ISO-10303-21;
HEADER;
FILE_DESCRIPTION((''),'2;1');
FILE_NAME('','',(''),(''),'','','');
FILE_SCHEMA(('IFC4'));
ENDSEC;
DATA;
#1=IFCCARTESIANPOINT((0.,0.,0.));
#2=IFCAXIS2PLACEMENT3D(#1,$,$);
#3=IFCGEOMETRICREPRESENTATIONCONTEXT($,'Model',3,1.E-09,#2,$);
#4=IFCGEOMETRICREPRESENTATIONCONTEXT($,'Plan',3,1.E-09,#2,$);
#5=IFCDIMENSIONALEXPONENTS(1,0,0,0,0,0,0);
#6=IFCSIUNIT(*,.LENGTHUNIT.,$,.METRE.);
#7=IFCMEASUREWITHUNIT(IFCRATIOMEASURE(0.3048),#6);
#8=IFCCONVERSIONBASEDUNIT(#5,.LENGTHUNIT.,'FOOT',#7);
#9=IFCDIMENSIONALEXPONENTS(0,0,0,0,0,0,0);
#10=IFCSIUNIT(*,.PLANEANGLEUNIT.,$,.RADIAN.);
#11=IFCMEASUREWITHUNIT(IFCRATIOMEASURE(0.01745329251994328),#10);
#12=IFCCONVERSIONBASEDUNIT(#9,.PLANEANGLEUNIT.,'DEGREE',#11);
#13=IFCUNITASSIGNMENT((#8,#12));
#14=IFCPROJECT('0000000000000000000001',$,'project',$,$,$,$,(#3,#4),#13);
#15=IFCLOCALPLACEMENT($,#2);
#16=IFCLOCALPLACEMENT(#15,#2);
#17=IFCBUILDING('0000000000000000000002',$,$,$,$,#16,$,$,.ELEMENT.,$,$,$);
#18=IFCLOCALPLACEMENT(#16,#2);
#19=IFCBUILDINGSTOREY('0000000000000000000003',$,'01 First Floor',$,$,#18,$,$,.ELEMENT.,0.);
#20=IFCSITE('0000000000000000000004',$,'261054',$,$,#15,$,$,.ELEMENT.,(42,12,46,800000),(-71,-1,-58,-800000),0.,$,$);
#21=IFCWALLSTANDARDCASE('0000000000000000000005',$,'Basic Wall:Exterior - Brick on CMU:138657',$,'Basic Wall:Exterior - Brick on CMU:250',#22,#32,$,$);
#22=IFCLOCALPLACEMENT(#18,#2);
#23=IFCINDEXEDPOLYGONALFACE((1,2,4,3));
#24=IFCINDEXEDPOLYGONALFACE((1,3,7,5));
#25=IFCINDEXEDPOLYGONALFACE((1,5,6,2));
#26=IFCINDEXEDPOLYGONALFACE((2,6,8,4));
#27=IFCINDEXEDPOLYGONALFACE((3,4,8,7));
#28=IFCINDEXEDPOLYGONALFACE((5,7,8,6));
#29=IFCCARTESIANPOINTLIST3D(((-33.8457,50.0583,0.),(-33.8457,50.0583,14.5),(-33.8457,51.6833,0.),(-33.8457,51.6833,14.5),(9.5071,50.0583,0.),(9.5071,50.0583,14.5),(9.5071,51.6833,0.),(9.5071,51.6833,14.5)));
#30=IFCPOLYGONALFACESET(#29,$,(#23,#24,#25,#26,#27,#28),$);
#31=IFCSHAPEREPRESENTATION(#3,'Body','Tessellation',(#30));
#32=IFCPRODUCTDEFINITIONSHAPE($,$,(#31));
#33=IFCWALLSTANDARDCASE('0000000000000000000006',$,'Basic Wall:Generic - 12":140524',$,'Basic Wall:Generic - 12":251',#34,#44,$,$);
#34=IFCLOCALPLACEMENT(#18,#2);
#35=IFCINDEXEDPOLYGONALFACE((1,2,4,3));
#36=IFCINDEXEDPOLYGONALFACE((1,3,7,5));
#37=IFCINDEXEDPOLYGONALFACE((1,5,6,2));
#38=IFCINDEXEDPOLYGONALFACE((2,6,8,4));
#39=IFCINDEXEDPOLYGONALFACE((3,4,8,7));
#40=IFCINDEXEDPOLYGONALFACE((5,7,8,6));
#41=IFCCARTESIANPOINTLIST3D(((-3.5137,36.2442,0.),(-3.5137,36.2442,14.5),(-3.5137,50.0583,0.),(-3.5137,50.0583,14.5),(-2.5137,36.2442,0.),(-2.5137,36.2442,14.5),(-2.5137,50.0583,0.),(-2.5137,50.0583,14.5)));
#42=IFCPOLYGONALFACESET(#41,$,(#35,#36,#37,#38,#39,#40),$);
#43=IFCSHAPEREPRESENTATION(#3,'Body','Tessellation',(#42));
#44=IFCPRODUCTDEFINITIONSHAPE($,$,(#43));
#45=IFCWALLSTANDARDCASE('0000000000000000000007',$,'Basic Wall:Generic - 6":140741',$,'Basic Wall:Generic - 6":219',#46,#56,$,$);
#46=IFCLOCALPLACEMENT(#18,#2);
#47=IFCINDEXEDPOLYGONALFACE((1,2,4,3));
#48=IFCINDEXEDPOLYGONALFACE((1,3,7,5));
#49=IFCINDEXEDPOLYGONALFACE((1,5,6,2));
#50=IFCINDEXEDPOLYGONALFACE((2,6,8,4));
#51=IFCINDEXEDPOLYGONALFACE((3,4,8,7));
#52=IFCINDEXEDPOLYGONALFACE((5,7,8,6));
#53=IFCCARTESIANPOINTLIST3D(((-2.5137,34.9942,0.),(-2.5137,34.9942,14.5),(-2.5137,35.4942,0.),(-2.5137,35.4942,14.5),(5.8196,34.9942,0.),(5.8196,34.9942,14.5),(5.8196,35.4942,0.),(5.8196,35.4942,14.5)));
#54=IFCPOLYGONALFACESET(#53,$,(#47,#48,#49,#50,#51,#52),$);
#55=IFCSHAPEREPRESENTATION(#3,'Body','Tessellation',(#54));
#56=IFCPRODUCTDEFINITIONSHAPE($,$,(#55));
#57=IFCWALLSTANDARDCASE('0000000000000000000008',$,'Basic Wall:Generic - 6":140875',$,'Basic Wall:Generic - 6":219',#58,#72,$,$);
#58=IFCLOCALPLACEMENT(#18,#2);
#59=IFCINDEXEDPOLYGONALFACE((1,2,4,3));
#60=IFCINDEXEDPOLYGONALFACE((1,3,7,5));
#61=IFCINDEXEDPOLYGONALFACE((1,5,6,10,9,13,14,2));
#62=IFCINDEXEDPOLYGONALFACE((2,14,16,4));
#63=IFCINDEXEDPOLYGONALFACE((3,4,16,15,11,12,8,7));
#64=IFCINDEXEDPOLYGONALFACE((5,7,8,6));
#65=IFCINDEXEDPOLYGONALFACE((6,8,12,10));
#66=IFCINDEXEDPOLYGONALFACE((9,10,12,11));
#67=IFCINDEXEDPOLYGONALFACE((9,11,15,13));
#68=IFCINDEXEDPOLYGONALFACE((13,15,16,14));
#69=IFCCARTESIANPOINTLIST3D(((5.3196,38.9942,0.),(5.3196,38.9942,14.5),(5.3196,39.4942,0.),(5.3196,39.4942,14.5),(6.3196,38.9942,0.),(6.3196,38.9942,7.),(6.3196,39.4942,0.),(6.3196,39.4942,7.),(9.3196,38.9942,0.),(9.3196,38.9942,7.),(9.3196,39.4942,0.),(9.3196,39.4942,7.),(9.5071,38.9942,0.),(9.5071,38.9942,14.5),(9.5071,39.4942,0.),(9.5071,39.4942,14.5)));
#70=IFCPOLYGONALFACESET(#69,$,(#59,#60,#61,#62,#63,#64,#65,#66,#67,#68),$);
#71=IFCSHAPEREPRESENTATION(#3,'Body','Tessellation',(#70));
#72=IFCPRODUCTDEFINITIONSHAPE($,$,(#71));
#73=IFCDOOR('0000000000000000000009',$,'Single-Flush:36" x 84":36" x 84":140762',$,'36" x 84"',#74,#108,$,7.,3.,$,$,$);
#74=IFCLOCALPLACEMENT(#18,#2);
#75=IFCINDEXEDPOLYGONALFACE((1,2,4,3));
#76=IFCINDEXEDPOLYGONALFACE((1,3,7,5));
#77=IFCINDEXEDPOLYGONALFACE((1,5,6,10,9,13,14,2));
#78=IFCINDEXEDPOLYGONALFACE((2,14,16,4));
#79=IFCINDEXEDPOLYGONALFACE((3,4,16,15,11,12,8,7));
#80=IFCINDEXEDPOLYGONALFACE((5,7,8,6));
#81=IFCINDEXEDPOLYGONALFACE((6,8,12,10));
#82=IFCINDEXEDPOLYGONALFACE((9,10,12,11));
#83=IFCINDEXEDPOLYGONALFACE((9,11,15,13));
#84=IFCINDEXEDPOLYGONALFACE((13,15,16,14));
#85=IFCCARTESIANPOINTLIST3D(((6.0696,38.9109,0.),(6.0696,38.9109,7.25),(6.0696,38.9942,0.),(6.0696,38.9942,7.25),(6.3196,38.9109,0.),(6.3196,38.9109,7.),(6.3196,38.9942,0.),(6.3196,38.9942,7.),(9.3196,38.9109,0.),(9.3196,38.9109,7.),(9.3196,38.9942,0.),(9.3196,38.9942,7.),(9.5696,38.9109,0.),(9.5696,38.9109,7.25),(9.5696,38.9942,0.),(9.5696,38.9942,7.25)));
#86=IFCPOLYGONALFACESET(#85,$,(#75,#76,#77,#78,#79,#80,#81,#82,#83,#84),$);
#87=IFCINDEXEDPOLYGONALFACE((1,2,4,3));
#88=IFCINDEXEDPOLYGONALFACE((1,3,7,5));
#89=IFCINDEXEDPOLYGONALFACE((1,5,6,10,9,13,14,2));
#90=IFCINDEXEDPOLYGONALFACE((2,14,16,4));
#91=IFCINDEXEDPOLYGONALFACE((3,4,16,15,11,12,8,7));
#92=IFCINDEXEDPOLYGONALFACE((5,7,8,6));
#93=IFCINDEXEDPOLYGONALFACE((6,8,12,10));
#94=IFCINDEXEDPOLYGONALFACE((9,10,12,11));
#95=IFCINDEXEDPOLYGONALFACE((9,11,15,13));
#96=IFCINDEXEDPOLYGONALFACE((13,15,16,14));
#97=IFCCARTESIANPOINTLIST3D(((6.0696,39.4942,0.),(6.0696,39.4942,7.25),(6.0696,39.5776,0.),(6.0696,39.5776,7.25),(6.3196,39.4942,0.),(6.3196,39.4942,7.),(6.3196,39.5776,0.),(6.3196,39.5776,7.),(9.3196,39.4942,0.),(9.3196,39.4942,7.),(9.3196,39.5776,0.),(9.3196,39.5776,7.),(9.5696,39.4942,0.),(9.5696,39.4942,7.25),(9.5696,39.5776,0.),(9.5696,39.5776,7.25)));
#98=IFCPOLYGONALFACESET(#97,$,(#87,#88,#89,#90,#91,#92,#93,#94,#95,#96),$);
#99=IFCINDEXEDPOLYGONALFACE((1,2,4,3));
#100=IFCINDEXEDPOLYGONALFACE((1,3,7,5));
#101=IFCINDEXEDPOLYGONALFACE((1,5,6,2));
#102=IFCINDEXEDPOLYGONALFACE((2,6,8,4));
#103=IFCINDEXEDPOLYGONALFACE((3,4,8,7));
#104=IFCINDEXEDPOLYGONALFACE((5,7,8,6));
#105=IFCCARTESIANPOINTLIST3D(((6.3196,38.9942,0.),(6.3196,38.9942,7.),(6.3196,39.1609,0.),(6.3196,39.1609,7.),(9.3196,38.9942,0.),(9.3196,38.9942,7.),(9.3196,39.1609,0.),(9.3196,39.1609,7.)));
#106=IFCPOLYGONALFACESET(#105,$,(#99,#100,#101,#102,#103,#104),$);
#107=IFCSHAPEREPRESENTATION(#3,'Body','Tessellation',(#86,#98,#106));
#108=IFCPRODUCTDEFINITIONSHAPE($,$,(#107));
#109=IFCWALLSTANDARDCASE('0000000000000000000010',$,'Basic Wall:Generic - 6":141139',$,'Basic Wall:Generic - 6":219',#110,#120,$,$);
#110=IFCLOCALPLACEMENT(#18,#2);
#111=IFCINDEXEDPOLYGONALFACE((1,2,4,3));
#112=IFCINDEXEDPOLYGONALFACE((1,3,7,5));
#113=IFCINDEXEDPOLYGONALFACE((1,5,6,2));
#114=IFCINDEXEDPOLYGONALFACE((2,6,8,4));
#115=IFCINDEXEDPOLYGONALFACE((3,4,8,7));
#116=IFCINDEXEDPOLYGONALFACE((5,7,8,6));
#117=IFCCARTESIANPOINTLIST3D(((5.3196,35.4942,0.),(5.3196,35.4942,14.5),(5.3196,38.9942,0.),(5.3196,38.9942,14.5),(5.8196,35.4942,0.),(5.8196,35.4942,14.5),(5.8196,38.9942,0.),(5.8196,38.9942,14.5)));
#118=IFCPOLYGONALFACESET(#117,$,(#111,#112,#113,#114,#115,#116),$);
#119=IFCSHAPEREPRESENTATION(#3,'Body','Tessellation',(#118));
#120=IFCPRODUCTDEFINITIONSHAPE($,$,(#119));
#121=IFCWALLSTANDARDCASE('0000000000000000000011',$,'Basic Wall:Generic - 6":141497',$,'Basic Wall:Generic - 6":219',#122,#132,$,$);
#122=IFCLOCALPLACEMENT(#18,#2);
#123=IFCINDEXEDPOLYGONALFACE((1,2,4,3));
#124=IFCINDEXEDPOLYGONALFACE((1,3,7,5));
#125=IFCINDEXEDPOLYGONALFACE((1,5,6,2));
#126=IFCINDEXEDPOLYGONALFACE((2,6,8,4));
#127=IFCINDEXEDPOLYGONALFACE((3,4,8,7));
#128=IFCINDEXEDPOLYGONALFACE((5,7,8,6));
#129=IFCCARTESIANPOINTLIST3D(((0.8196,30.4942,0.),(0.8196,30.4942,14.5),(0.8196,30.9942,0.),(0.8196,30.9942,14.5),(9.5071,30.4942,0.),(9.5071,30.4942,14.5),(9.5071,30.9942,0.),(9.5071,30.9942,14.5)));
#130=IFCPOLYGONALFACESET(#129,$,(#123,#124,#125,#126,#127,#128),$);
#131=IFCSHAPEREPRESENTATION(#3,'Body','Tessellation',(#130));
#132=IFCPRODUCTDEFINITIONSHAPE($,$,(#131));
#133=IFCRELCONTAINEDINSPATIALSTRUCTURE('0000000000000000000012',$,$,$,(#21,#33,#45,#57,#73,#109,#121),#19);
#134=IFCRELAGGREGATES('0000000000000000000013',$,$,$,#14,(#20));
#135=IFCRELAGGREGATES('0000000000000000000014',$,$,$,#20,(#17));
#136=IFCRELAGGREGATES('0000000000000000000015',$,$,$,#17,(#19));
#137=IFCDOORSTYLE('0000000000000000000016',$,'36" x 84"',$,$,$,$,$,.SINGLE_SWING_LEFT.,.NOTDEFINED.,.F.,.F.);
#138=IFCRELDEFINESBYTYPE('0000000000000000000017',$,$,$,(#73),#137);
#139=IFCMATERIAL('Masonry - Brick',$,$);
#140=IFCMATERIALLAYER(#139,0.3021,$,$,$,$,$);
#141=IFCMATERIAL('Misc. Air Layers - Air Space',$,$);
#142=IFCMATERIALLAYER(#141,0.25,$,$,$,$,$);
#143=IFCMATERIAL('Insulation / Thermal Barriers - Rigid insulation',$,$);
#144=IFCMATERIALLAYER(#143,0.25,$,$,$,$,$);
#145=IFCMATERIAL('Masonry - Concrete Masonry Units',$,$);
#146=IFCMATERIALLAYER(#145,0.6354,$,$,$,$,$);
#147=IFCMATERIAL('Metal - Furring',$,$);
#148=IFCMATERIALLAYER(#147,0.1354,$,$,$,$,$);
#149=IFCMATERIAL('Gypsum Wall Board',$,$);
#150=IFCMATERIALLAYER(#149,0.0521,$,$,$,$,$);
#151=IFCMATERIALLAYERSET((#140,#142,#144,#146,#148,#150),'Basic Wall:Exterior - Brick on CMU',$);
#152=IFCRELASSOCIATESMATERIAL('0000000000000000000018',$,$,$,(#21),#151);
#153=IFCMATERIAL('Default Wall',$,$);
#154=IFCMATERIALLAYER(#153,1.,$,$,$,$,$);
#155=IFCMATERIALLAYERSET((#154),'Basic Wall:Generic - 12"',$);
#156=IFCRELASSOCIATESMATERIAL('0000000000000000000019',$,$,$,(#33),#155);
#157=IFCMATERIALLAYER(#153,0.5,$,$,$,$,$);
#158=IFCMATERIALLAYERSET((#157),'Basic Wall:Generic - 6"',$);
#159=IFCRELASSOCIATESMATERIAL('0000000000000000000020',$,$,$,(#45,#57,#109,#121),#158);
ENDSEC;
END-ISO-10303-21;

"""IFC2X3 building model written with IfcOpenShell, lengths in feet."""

from ifc_helpers import new_model, entity, si_unit, converted_unit, frame, frame_2d, origin, origin_2d_with_axis, place, context, project, spatial, polyline, rectangle, outline, extrude, clip, bounded_halfspace, source, transform, mapped, material, layer, layer_set, layer_usage, type_object, type_shapes, element, fill, save


model = new_model("IFC2X3")

# Units and contexts
model_context = context("Model", 3, precision=1e-09, world=origin())
plan_context = context("Plan", 3, precision=1e-09, world=origin())
ifc_project = project(units=[converted_unit("LENGTHUNIT", "FOOT", entity("IfcRatioMeasure", 0.3048), si_unit("LENGTHUNIT", "METRE"), dimensions=[1, 0, 0, 0, 0, 0, 0]), converted_unit("PLANEANGLEUNIT", "DEGREE", entity("IfcRatioMeasure", 0.01745329251994328), si_unit("PLANEANGLEUNIT", "RADIAN"), dimensions=[0, 0, 0, 0, 0, 0, 0])], contexts=[model_context, plan_context])

# Site, building, storey
site_placement = place(None, origin())
site = spatial("IfcSite", under=ifc_project, at=site_placement, Name="261054", CompositionType="ELEMENT", RefLatitude=(42, 12, 46, 800000), RefLongitude=(-71, -1, -58, -800000), RefElevation=0.0)
building_placement = place(site_placement, origin())
building = spatial("IfcBuilding", under=site, at=building_placement, CompositionType="ELEMENT")
storey_placement = place(building_placement, origin())
storey = spatial("IfcBuildingStorey", under=building, at=storey_placement, Name="01 First Floor", CompositionType="ELEMENT", Elevation=0.0)

# Walls
ifc_material_1 = material(Name="Masonry - Brick")
ifc_layer_1 = layer(ifc_material_1, 0.3021)
ifc_material_2 = material(Name="Misc. Air Layers - Air Space")
ifc_layer_2 = layer(ifc_material_2, 0.25)
ifc_material_3 = material(Name="Insulation / Thermal Barriers - Rigid insulation")
ifc_layer_3 = layer(ifc_material_3, 0.25)
ifc_material_4 = material(Name="Masonry - Concrete Masonry Units")
ifc_layer_4 = layer(ifc_material_4, 0.6354)
ifc_material_5 = material(Name="Metal - Furring")
ifc_layer_5 = layer(ifc_material_5, 0.1354)
ifc_material_6 = material(Name="Gypsum Wall Board")
ifc_layer_6 = layer(ifc_material_6, 0.0521)
ifc_layer_set_1 = layer_set([ifc_layer_1, ifc_layer_2, ifc_layer_3, ifc_layer_4, ifc_layer_5, ifc_layer_6], Name="Basic Wall:Exterior - Brick on CMU")
ifc_layer_usage_1 = layer_usage(ifc_layer_set_1, "AXIS2", "POSITIVE", -0.8125)
wall_1_placement = place(storey_placement, frame((9.5071, 50.8708, 0.0), z_axis=(0.0, 0.0, 1.0), x_axis=(-1.0, 0.0, 0.0)))
element("IfcWallStandardCase", 1, at=wall_1_placement, inside=storey, material=ifc_layer_usage_1, Name="Basic Wall:Exterior - Brick on CMU:138657", ObjectType="Basic Wall:Exterior - Brick on CMU:250", context=model_context, shape_type="Clipping", body=[
    clip(extrude(rectangle(XDim=43.3528, YDim=1.625, at=frame_2d((21.6764, 0.0), x_axis=(-1.0, 0.0))), origin(), (0.0, 0.0, 1.0), 14.5), bounded_halfspace(frame((0.0, -0.8125, 14.5), z_axis=(0.0, 0.0, -1.0), x_axis=(-1.0, 0.0, 0.0)), True, frame((0.0, -0.8125, 14.5)), polyline([(0.0, 0.0), (8.1875, 0.0), (43.3528, 0.0), (43.3528, 1.625), (41.7278, 1.625), (13.0208, 1.625), (12.0208, 1.625), (0.0, 1.625), (0.0, 0.0)]))),
])
ifc_material_7 = material(Name="Default Wall")
ifc_layer_7 = layer(ifc_material_7, 1.0)
ifc_layer_set_2 = layer_set([ifc_layer_7], Name="Basic Wall:Generic - 12\"")
ifc_layer_usage_2 = layer_usage(ifc_layer_set_2, "AXIS2", "NEGATIVE", 0.5)
wall_2_placement = place(storey_placement, frame((-3.0137, 36.2442, 0.0), z_axis=(0.0, 0.0, 1.0), x_axis=(0.0, 1.0, 0.0)))
element("IfcWallStandardCase", 2, at=wall_2_placement, inside=storey, material=ifc_layer_usage_2, Name="Basic Wall:Generic - 12\":140524", ObjectType="Basic Wall:Generic - 12\":251", context=model_context, shape_type="Clipping", body=[
    clip(extrude(rectangle(XDim=13.814, YDim=1.0, at=frame_2d((6.907, 0.0), x_axis=(-1.0, 0.0))), origin(), (0.0, 0.0, 1.0), 14.5), bounded_halfspace(frame((0.0, -0.5, 14.5), z_axis=(0.0, 0.0, -1.0), x_axis=(0.0, -1.0, 0.0)), True, frame((0.0, -0.5, 14.5)), polyline([(0.0, 0.0), (13.814, 0.0), (13.814, 1.0), (0.0, 1.0), (0.0, 0.0)]))),
])
ifc_layer_8 = layer(ifc_material_7, 0.5)
ifc_layer_set_3 = layer_set([ifc_layer_8], Name="Basic Wall:Generic - 6\"")
ifc_layer_usage_3 = layer_usage(ifc_layer_set_3, "AXIS2", "NEGATIVE", 0.25)
wall_3_placement = place(storey_placement, frame((-2.5137, 35.2442, 0.0)))
element("IfcWallStandardCase", 3, at=wall_3_placement, inside=storey, material=ifc_layer_usage_3, Name="Basic Wall:Generic - 6\":140741", ObjectType="Basic Wall:Generic - 6\":219", context=model_context, shape_type="Clipping", body=[
    clip(extrude(rectangle(XDim=8.3333, YDim=0.5, at=frame_2d((4.1667, 0.0), x_axis=(-1.0, 0.0))), origin(), (0.0, 0.0, 1.0), 14.5), bounded_halfspace(frame((0.0, -0.25, 14.5), z_axis=(0.0, 0.0, -1.0), x_axis=(1.0, 0.0, 0.0)), True, frame((0.0, -0.25, 14.5)), polyline([(0.0, 0.0), (8.3333, 0.0), (8.3333, 0.5), (7.8333, 0.5), (0.0, 0.5), (0.0, 0.0)]))),
])

# Wall, opening, door
ifc_layer_usage_4 = layer_usage(ifc_layer_set_3, "AXIS2", "NEGATIVE", 0.25)
wall_4_placement = place(storey_placement, frame((5.3196, 39.2442, 0.0)))
wall_4 = element("IfcWallStandardCase", 4, at=wall_4_placement, inside=storey, material=ifc_layer_usage_4, Name="Basic Wall:Generic - 6\":140875", ObjectType="Basic Wall:Generic - 6\":219", context=model_context, shape_type="Clipping", body=[
    clip(extrude(rectangle(XDim=4.1875, YDim=0.5, at=frame_2d((2.0938, 0.0), x_axis=(-1.0, 0.0))), origin(), (0.0, 0.0, 1.0), 14.5), bounded_halfspace(frame((0.0, -0.25, 14.5), z_axis=(0.0, 0.0, -1.0), x_axis=(1.0, 0.0, 0.0)), True, frame((0.0, -0.25, 14.5)), polyline([(0.0, 0.0), (0.5, 0.0), (4.1875, 0.0), (4.1875, 0.5), (0.0, 0.5), (0.0, 0.0)]))),
])
opening_1_placement = place(wall_4_placement, frame((4.0, 0.25, 0.0)))
opening_1 = element("IfcOpeningElement", 5, at=opening_1_placement, cuts=wall_4, ObjectType="Opening", context=model_context, shape_type="SweptSolid", body=[
    extrude(rectangle(XDim=3.0, YDim=7.0, at=frame_2d((3.5, 1.5), x_axis=(0.0, -1.0))), frame((0.0, 0.0, 0.0), z_axis=(0.0, -1.0, 0.0), x_axis=(0.0, 0.0, 1.0)), (0.0, 0.0, 1.0), 0.5),
])
door_style_1 = type_object("IfcDoorStyle", Name="36\" x 84\"", ConstructionType="NOTDEFINED", OperationType="SINGLE_SWING_LEFT", ParameterTakesPrecedence=False, Sizeable=False)
shared_shape_1 = source(origin(), model_context, "Body", "SweptSolid", [
    extrude(outline(polyline([(-1.75, -3.6875), (1.75, -3.6875), (1.75, 3.5625), (1.5, 3.5625), (1.5, -3.4375), (-1.5, -3.4375), (-1.5, 3.5625), (-1.75, 3.5625), (-1.75, -3.6875)])), frame((1.5, 0.5833, 3.5625), z_axis=(0.0, -1.0, 0.0), x_axis=(-1.0, 0.0, 0.0)), (0.0, 0.0, 1.0), 0.0833),
    extrude(outline(polyline([(-3.6875, -1.75), (3.5625, -1.75), (3.5625, -1.5), (-3.4375, -1.5), (-3.4375, 1.5), (3.5625, 1.5), (3.5625, 1.75), (-3.6875, 1.75), (-3.6875, -1.75)])), frame((1.5, 0.0, 3.5625), z_axis=(0.0, -1.0, 0.0), x_axis=(0.0, 0.0, -1.0)), (0.0, 0.0, 1.0), 0.0833),
    extrude(rectangle(XDim=3.0, YDim=0.1667, at=origin_2d_with_axis()), frame((1.5, 0.4167, 0.0)), (0.0, 0.0, 1.0), 7.0),
])
type_shapes(door_style_1, [shared_shape_1])
door_1_placement = place(opening_1_placement, frame((0.0, 0.0, 0.0), z_axis=(0.0, 0.0, 1.0), x_axis=(-1.0, 0.0, 0.0)))
door_1 = element("IfcDoor", 6, at=door_1_placement, inside=storey, type_object=door_style_1, Name="Single-Flush:36\" x 84\":36\" x 84\":140762", ObjectType="36\" x 84\"", OverallHeight=7.0, OverallWidth=3.0, context=model_context, shape_type="MappedRepresentation", body=[
    mapped(shared_shape_1, transform((0.0, 0.0, 0.0), scale=1.0)),
])
fill(opening_1, door_1)

# Walls
ifc_layer_usage_5 = layer_usage(ifc_layer_set_3, "AXIS2", "NEGATIVE", 0.25)
wall_5_placement = place(storey_placement, frame((5.5696, 35.4942, 0.0), z_axis=(0.0, 0.0, 1.0), x_axis=(0.0, 1.0, 0.0)))
element("IfcWallStandardCase", 7, at=wall_5_placement, inside=storey, material=ifc_layer_usage_5, Name="Basic Wall:Generic - 6\":141139", ObjectType="Basic Wall:Generic - 6\":219", context=model_context, shape_type="Clipping", body=[
    clip(extrude(rectangle(XDim=3.5, YDim=0.5, at=frame_2d((1.75, 0.0), x_axis=(-1.0, 0.0))), origin(), (0.0, 0.0, 1.0), 14.5), bounded_halfspace(frame((0.0, -0.25, 14.5), z_axis=(0.0, 0.0, -1.0), x_axis=(0.0, -1.0, 0.0)), True, frame((0.0, -0.25, 14.5)), polyline([(0.0, 0.0), (3.5, 0.0), (3.5, 0.5), (0.0, 0.5), (0.0, 0.0)]))),
])
ifc_layer_usage_6 = layer_usage(ifc_layer_set_3, "AXIS2", "NEGATIVE", 0.25)
wall_6_placement = place(storey_placement, frame((0.8196, 30.7442, 0.0)))
element("IfcWallStandardCase", 8, at=wall_6_placement, inside=storey, material=ifc_layer_usage_6, Name="Basic Wall:Generic - 6\":141497", ObjectType="Basic Wall:Generic - 6\":219", context=model_context, shape_type="Clipping", body=[
    clip(extrude(rectangle(XDim=8.6875, YDim=0.5, at=frame_2d((4.3437, 0.0), x_axis=(-1.0, 0.0))), origin(), (0.0, 0.0, 1.0), 14.5), bounded_halfspace(frame((0.0, -0.25, 14.5), z_axis=(0.0, 0.0, -1.0), x_axis=(1.0, 0.0, 0.0)), True, frame((0.0, -0.25, 14.5)), polyline([(0.0, 0.0), (0.5, 0.0), (8.6875, 0.0), (8.6875, 0.5), (0.0, 0.5), (0.0, 0.0)]))),
])

save(model, "model.ifc")
